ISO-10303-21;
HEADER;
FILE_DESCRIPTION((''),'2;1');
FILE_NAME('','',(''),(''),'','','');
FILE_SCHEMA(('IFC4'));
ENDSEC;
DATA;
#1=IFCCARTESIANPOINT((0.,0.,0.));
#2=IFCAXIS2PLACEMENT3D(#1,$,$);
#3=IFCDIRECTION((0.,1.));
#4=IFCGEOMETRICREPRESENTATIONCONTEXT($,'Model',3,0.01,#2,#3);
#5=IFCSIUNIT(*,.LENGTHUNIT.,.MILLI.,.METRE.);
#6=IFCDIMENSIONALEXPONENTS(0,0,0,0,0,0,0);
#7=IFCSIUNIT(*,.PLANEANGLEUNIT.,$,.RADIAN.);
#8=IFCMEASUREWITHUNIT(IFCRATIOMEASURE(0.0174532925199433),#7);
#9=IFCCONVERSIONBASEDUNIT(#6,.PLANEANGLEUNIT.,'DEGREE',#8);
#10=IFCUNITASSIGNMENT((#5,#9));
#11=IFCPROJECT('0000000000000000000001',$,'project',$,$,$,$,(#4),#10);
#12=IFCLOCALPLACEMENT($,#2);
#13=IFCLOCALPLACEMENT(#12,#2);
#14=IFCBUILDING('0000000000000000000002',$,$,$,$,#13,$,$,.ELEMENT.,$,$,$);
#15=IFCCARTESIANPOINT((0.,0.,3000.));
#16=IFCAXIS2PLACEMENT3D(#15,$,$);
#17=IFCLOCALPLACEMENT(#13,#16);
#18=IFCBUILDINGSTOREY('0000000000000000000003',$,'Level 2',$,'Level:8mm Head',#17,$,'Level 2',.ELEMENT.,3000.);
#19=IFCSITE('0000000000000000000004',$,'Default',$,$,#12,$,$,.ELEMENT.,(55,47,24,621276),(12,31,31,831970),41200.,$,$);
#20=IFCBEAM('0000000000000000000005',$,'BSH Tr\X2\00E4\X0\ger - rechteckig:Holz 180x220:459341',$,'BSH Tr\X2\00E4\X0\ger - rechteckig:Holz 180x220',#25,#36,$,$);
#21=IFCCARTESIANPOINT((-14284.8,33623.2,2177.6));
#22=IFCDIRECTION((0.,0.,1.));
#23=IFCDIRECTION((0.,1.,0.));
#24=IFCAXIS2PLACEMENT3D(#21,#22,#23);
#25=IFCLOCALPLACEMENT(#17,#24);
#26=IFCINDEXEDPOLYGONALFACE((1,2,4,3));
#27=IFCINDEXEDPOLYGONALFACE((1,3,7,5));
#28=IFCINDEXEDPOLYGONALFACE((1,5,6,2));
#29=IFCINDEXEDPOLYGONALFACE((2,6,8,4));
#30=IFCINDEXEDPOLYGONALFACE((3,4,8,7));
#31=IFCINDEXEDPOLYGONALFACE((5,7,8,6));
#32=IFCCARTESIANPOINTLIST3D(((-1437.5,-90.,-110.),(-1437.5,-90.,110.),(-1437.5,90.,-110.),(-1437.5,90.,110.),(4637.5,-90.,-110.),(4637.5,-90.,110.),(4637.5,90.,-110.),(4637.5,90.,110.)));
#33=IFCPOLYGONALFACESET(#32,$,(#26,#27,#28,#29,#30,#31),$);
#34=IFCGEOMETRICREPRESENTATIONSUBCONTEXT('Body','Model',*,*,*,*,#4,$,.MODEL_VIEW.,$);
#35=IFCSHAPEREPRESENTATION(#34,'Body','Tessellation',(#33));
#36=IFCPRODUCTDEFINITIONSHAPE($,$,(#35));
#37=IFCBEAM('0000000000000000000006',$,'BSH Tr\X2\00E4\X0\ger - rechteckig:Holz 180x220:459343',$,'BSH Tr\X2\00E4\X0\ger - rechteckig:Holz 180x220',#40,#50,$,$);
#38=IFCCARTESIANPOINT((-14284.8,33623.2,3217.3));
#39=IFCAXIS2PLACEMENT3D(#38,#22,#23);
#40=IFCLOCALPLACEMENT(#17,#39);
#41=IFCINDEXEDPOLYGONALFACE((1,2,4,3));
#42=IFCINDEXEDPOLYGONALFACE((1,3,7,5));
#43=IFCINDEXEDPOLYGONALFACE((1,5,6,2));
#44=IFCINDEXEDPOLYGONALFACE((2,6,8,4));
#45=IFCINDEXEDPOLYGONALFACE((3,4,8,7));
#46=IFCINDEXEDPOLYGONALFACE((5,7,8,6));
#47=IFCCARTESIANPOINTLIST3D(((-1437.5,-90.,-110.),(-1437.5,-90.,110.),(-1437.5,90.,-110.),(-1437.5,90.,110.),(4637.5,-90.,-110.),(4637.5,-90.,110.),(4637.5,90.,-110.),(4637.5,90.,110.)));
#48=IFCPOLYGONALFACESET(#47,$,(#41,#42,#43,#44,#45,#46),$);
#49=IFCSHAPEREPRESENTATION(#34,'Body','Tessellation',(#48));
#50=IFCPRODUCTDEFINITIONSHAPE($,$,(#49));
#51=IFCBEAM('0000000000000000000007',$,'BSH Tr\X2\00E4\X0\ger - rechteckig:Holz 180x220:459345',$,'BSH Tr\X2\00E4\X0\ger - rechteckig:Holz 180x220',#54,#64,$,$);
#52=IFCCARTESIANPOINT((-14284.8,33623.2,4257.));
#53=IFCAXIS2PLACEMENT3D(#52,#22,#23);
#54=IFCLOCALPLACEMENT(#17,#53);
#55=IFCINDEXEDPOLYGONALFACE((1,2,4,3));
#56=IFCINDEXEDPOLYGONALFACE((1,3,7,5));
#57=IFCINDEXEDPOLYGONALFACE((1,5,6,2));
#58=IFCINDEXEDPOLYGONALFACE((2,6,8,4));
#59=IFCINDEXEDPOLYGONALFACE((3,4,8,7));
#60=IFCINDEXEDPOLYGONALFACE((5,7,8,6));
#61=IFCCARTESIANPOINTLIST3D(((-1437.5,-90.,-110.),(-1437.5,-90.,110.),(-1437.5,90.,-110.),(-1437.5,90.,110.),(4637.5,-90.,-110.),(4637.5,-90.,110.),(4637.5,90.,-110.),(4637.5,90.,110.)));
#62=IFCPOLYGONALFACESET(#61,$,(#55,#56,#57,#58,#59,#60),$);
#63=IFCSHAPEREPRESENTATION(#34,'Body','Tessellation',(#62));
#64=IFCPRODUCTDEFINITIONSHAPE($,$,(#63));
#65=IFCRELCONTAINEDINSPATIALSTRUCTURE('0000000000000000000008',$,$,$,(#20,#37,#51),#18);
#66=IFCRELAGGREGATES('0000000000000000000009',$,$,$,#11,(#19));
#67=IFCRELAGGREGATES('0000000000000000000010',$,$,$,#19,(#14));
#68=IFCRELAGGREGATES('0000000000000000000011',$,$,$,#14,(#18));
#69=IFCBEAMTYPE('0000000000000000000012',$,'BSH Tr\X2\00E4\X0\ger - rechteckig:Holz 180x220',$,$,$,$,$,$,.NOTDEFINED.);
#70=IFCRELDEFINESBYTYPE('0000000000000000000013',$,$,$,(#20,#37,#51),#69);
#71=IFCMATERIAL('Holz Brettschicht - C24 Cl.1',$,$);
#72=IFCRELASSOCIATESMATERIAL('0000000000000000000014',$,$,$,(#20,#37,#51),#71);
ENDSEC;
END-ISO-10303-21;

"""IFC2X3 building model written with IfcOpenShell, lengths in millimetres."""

from ifc_helpers import new_model, entity, si_unit, converted_unit, direction, frame, frame_2d, origin, place, context, subcontext, project, spatial, rectangle, extrude, material, type_object, element, save


model = new_model("IFC2X3")

# Units and contexts
model_context = context("Model", 3, precision=0.01, world=origin(), true_north=direction((0.0, 1.0)))
body_context = subcontext(model_context, "Body", "Model", "MODEL_VIEW")
ifc_project = project(units=[si_unit("LENGTHUNIT", "METRE", prefix="MILLI"), converted_unit("PLANEANGLEUNIT", "DEGREE", entity("IfcRatioMeasure", 0.0174532925199433), si_unit("PLANEANGLEUNIT", "RADIAN"), dimensions=[0, 0, 0, 0, 0, 0, 0])], contexts=[model_context])

# Site, building, storey
site_placement = place(None, origin())
site = spatial("IfcSite", under=ifc_project, at=site_placement, Name="Default", CompositionType="ELEMENT", RefLatitude=(55, 47, 24, 621276), RefLongitude=(12, 31, 31, 831970), RefElevation=41200.0)
building_placement = place(site_placement, origin())
building = spatial("IfcBuilding", under=site, at=building_placement, CompositionType="ELEMENT")
storey_placement = place(building_placement, frame((0.0, 0.0, 3000.0)))
storey = spatial("IfcBuildingStorey", under=building, at=storey_placement, Name="Level 2", ObjectType="Level:8mm Head", LongName="Level 2", CompositionType="ELEMENT", Elevation=3000.0)

# Beams
ifc_material_1 = material(Name="Holz Brettschicht - C24 Cl.1")
beam_type_1 = type_object("IfcBeamType", Name="BSH Träger - rechteckig:Holz 180x220", PredefinedType="NOTDEFINED")
for number, where, z_axis, x_axis, name in (
    (1, (-14284.8, 33623.2, 2177.6), (0.0, 0.0, 1.0), (0.0, 1.0, 0.0), "BSH Träger - rechteckig:Holz 180x220:459341"),
    (2, (-14284.8, 33623.2, 3217.3), (0.0, 0.0, 1.0), (0.0, 1.0, 0.0), "BSH Träger - rechteckig:Holz 180x220:459343"),
):
    element("IfcBeam", number, at=place(storey_placement, frame(where, z_axis=z_axis, x_axis=x_axis)), inside=storey, type_object=beam_type_1, material=ifc_material_1, Name=name, ObjectType="BSH Träger - rechteckig:Holz 180x220", context=body_context, shape_type="SweptSolid", body=[
        extrude(rectangle(XDim=220.0, YDim=180.0, at=frame_2d((0.0, 0.0), x_axis=(1.0, 0.0))), frame((-1437.5, 0.0, 0.0), z_axis=(1.0, 0.0, 0.0), x_axis=(0.0, 0.0, -1.0)), (0.0, 0.0, 1.0), 6075.0),
    ])
beam_1_placement = place(storey_placement, frame((-14284.8, 33623.2, 4257.0), z_axis=(0.0, 0.0, 1.0), x_axis=(0.0, 1.0, 0.0)))
element("IfcBeam", 3, at=beam_1_placement, inside=storey, type_object=beam_type_1, material=ifc_material_1, Name="BSH Träger - rechteckig:Holz 180x220:459345", ObjectType="BSH Träger - rechteckig:Holz 180x220", context=body_context, shape_type="SweptSolid", body=[
    extrude(rectangle(XDim=220.0, YDim=180.0, at=frame_2d((0.0, 0.0), x_axis=(1.0, 0.0))), frame((-1437.5, 0.0, 0.0), z_axis=(1.0, 0.0, 0.0), x_axis=(0.0, 0.0, -1.0)), (0.0, 0.0, 1.0), 6075.0),
])

save(model, "model.ifc")
